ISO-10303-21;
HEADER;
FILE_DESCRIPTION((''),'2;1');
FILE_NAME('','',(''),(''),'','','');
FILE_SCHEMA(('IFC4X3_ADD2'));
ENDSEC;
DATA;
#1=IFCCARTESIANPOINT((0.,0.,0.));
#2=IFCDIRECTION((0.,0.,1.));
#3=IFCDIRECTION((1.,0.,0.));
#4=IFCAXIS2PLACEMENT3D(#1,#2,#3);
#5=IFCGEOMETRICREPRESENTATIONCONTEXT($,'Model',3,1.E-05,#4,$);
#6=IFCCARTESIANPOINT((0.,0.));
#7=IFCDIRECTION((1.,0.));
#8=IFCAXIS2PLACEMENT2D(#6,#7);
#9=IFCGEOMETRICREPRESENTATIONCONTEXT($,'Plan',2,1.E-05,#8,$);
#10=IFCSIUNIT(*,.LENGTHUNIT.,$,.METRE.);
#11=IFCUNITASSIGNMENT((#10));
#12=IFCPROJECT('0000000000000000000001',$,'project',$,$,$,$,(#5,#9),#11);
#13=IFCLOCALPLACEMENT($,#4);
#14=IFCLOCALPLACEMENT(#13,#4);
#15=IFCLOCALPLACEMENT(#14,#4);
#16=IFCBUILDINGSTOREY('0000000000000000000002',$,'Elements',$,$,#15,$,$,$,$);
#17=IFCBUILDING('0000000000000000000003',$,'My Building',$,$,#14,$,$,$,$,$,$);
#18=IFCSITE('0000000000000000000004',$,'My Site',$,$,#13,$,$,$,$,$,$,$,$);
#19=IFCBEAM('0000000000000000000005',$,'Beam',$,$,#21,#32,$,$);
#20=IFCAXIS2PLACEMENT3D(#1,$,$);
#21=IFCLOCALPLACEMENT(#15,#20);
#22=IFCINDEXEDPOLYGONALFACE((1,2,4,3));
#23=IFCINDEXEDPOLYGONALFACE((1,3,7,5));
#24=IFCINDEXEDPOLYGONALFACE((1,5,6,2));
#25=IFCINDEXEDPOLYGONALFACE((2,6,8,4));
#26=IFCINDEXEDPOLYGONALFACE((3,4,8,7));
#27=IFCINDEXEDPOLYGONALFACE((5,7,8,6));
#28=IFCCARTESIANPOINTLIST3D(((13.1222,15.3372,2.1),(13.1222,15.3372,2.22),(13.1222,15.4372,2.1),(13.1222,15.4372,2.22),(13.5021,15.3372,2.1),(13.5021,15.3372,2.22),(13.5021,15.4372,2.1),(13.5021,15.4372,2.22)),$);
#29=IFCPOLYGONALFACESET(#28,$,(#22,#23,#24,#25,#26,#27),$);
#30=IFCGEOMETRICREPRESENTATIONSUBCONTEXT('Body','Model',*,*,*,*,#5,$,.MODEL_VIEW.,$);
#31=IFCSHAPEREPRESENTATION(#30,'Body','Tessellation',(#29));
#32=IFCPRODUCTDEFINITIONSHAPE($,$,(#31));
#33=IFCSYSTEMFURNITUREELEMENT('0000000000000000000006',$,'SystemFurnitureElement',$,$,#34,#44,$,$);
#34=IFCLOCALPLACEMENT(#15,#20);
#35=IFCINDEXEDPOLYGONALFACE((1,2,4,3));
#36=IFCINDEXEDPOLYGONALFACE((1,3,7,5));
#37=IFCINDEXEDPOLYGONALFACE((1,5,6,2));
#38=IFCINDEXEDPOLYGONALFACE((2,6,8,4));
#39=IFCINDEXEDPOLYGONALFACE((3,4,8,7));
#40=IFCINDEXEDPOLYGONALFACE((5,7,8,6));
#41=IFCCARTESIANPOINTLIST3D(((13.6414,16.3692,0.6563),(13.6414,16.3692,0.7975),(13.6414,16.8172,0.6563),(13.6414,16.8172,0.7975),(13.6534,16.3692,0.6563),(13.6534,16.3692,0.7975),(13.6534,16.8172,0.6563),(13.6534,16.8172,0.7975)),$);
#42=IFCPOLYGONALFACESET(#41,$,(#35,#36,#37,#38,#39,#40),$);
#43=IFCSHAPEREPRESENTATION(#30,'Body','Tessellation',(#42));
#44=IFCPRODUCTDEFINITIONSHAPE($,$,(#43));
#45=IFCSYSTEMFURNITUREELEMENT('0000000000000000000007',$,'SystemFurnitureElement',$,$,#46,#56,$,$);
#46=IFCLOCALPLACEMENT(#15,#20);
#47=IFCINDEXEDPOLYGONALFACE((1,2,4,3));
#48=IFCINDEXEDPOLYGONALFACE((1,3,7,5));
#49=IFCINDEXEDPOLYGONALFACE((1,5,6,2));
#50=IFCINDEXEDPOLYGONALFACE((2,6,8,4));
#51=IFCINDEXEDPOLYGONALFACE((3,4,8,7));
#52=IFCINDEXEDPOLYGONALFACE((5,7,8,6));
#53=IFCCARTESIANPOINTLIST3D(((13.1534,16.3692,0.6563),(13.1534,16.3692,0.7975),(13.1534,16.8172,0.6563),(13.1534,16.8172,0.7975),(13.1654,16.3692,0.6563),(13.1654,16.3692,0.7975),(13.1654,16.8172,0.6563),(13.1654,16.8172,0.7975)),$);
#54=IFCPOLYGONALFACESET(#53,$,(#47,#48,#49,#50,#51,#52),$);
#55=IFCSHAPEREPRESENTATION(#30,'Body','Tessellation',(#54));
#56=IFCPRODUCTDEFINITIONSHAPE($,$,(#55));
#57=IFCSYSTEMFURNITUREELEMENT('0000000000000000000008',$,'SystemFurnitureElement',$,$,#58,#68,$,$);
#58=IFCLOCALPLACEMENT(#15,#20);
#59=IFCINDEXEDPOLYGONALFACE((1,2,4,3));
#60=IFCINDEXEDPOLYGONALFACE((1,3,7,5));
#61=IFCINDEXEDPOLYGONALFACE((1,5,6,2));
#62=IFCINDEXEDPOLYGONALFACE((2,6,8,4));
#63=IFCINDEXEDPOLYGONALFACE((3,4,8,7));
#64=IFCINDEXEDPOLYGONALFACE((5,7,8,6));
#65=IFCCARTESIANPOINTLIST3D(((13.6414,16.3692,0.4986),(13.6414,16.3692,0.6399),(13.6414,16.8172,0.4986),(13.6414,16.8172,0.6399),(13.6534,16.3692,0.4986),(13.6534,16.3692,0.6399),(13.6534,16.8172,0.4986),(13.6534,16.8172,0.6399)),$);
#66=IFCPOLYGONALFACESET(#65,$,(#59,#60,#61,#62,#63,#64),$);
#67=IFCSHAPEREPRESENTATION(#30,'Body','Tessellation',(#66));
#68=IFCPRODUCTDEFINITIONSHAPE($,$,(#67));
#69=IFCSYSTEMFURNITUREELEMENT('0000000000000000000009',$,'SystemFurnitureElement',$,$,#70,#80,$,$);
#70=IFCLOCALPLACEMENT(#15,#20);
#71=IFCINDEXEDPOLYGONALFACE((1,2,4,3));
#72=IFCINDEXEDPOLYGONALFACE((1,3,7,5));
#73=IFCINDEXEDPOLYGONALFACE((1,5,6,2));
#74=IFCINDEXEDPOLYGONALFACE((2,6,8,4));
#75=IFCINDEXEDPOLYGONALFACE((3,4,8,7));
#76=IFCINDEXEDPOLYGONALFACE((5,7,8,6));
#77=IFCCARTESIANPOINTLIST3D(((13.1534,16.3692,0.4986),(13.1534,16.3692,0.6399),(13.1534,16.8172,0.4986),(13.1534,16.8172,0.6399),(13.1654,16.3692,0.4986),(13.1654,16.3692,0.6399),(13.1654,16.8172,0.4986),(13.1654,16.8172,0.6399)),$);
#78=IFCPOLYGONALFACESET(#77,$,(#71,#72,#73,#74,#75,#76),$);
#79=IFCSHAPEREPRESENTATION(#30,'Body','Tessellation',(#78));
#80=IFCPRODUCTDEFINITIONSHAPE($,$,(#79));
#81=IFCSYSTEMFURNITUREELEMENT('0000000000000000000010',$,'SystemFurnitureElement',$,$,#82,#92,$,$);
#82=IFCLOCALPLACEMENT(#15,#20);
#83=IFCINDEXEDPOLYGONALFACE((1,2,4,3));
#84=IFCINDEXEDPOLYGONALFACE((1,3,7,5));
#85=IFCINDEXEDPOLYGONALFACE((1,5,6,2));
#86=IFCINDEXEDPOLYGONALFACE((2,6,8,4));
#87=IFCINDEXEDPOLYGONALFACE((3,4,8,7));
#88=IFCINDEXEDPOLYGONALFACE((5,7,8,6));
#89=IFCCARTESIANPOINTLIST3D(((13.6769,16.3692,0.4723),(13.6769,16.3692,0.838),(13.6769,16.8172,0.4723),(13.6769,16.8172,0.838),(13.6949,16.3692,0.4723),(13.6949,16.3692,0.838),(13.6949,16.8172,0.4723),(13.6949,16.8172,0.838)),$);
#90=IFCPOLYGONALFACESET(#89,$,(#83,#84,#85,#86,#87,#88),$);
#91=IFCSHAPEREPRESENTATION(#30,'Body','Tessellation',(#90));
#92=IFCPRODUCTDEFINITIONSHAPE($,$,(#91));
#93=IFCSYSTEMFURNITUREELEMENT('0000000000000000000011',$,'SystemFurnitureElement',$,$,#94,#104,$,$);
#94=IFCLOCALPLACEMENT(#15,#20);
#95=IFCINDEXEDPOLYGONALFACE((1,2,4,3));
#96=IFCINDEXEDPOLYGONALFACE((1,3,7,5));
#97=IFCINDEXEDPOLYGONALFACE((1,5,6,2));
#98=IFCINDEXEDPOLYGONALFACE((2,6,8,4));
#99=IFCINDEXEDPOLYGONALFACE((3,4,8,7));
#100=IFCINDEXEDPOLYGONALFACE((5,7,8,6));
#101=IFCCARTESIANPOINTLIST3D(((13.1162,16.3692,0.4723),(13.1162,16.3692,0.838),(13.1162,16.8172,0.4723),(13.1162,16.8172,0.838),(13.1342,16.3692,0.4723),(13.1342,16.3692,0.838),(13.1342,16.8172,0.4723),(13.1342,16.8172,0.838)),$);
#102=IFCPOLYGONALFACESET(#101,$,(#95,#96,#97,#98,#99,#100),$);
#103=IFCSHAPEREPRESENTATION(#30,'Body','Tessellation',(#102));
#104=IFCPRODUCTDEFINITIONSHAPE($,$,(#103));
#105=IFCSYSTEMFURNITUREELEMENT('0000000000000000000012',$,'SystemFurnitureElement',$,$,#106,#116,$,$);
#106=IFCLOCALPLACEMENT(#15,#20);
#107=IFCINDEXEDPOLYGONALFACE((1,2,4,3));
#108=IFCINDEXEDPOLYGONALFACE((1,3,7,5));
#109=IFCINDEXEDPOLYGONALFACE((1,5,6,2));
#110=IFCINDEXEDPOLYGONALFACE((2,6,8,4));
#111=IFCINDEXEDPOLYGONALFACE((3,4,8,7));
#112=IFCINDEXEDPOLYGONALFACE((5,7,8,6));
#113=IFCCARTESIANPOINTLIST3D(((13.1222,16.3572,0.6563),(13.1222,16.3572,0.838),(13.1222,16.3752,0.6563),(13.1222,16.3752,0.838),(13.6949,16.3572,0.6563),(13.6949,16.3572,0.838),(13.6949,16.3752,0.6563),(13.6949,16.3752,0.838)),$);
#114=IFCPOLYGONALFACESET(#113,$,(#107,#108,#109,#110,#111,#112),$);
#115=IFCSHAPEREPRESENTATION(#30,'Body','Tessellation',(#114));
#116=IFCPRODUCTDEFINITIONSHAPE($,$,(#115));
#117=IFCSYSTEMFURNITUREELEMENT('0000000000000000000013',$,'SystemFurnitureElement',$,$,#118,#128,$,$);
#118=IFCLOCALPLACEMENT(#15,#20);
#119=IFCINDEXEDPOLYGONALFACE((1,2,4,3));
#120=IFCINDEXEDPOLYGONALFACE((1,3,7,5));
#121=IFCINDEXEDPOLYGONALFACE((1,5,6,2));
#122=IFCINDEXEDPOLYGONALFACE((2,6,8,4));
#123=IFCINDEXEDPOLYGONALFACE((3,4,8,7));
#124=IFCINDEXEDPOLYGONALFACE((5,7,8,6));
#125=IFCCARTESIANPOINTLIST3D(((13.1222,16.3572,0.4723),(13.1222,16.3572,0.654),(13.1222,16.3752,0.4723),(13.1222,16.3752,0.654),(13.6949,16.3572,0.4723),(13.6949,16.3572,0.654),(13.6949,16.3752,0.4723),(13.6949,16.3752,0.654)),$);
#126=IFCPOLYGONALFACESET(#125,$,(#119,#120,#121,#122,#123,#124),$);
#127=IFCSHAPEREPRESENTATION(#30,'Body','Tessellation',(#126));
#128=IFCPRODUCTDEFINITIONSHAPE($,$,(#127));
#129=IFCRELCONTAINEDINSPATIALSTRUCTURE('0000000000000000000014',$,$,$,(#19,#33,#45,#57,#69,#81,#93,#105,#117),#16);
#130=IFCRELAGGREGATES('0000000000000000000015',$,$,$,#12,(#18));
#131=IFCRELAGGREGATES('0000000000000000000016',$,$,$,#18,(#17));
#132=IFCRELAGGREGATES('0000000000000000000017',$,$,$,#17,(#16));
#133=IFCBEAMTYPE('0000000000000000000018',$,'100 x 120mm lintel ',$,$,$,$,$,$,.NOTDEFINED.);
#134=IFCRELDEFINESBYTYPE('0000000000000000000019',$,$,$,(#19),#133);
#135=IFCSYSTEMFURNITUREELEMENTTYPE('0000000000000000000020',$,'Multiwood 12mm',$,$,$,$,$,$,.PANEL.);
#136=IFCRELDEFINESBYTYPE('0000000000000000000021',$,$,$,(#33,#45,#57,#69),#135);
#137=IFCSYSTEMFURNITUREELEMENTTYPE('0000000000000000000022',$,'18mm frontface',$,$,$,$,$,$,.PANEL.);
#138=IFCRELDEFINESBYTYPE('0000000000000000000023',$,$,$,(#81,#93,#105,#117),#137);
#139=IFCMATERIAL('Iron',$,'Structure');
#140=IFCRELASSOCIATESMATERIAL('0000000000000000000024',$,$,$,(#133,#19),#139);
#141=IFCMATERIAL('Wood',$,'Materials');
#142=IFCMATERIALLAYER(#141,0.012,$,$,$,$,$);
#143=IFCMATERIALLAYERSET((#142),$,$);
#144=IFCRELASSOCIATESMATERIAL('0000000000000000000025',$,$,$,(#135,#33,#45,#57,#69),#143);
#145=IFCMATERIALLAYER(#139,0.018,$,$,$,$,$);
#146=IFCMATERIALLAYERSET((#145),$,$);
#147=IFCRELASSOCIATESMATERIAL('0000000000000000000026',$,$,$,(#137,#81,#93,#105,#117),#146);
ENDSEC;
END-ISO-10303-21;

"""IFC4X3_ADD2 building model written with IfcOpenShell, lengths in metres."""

from ifc_helpers import new_model, si_unit, frame, origin_with_axes, origin_2d_with_axis, place, context, subcontext, project, spatial, line, indexed_curve, rectangle, outline, extrude, material, layer, layer_set, layer_usage, material_profile, profile_set, profile_usage, type_object, element, save


model = new_model("IFC4X3_ADD2")

# Units and contexts
model_context = context("Model", 3, precision=1e-05, world=origin_with_axes())
plan_context = context("Plan", 2, precision=1e-05, world=origin_2d_with_axis())
body_context = subcontext(model_context, "Body", "Model", "MODEL_VIEW")
ifc_project = project(units=[si_unit("LENGTHUNIT", "METRE")], contexts=[model_context, plan_context])

# Site, building, storey
site_placement = place(None, origin_with_axes())
site = spatial("IfcSite", under=ifc_project, at=site_placement, Name="My Site")
building_placement = place(site_placement, origin_with_axes())
building = spatial("IfcBuilding", under=site, at=building_placement, Name="My Building")
storey_placement = place(building_placement, origin_with_axes())
storey = spatial("IfcBuildingStorey", under=building, at=storey_placement, Name="Elements")

# Beam
ifc_material_1 = material(Name="Iron", Category="Structure")
ifc_material_profile = material_profile(ifc_material_1, rectangle(XDim=0.1, YDim=0.12))
ifc_profile_set = profile_set([ifc_material_profile], Name="blank")
ifc_profile_usage = profile_usage(ifc_profile_set, cardinal=5)
beam_type = type_object("IfcBeamType", Name="100 x 120mm lintel ", PredefinedType="NOTDEFINED", material=ifc_profile_set)
beam_placement = place(storey_placement, frame((13.1222, 15.3872, 2.16), z_axis=(1.0, 0.0, 0.0), x_axis=(0.0, 1.0, 0.0)))
element("IfcBeam", 1, at=beam_placement, inside=storey, type_object=beam_type, material=ifc_profile_usage, Name="Beam", context=body_context, shape_type="SweptSolid", body=[
    extrude(rectangle(XDim=0.1, YDim=0.12), origin_with_axes(), (0.0, 0.0, 1.0), 0.3799),
])

# System furniture elements
ifc_material_2 = material(Name="Wood", Category="Materials")
ifc_layer_1 = layer(ifc_material_2, 0.012)
ifc_layer_set_1 = layer_set([ifc_layer_1])
ifc_layer_usage_1 = layer_usage(ifc_layer_set_1, "AXIS2", "POSITIVE", 0.0)
system_furniture_element_type_1 = type_object("IfcSystemFurnitureElementType", Name="Multiwood 12mm", PredefinedType="PANEL", material=ifc_layer_set_1)
system_furniture_element_1_placement = place(storey_placement, frame((13.6534, 16.3692, 0.6563), z_axis=(0.0, 0.0, 1.0), x_axis=(0.000001, 1.0, 0.0)))
element("IfcSystemFurnitureElement", 2, at=system_furniture_element_1_placement, inside=storey, type_object=system_furniture_element_type_1, material=ifc_layer_usage_1, Name="SystemFurnitureElement", context=body_context, shape_type="SweptSolid", body=[
    extrude(outline(indexed_curve([(0.0, 0.0), (0.0, 0.012), (0.448, 0.012), (0.448, 0.0)], segments=[line(1, 2, 3, 4, 1)])), origin_with_axes(), (0.0, 0.0, 1.0), 0.1413),
])
ifc_layer_usage_2 = layer_usage(ifc_layer_set_1, "AXIS2", "POSITIVE", 0.0)
system_furniture_element_2_placement = place(storey_placement, frame((13.1654, 16.3692, 0.6563), z_axis=(0.0, 0.0, 1.0), x_axis=(0.000001, 1.0, 0.0)))
element("IfcSystemFurnitureElement", 3, at=system_furniture_element_2_placement, inside=storey, type_object=system_furniture_element_type_1, material=ifc_layer_usage_2, Name="SystemFurnitureElement", context=body_context, shape_type="SweptSolid", body=[
    extrude(outline(indexed_curve([(0.0, 0.0), (0.0, 0.012), (0.448, 0.012), (0.448, 0.0)], segments=[line(1, 2, 3, 4, 1)])), origin_with_axes(), (0.0, 0.0, 1.0), 0.1413),
])
ifc_layer_usage_3 = layer_usage(ifc_layer_set_1, "AXIS2", "POSITIVE", 0.0)
system_furniture_element_3_placement = place(storey_placement, frame((13.6534, 16.3692, 0.4986), z_axis=(0.0, 0.0, 1.0), x_axis=(0.000001, 1.0, 0.0)))
element("IfcSystemFurnitureElement", 4, at=system_furniture_element_3_placement, inside=storey, type_object=system_furniture_element_type_1, material=ifc_layer_usage_3, Name="SystemFurnitureElement", context=body_context, shape_type="SweptSolid", body=[
    extrude(outline(indexed_curve([(0.0, 0.0), (0.0, 0.012), (0.448, 0.012), (0.448, 0.0)], segments=[line(1, 2, 3, 4, 1)])), origin_with_axes(), (0.0, 0.0, 1.0), 0.1413),
])
ifc_layer_usage_4 = layer_usage(ifc_layer_set_1, "AXIS2", "POSITIVE", 0.0)
system_furniture_element_4_placement = place(storey_placement, frame((13.1654, 16.3692, 0.4986), z_axis=(0.0, 0.0, 1.0), x_axis=(0.000001, 1.0, 0.0)))
element("IfcSystemFurnitureElement", 5, at=system_furniture_element_4_placement, inside=storey, type_object=system_furniture_element_type_1, material=ifc_layer_usage_4, Name="SystemFurnitureElement", context=body_context, shape_type="SweptSolid", body=[
    extrude(outline(indexed_curve([(0.0, 0.0), (0.0, 0.012), (0.448, 0.012), (0.448, 0.0)], segments=[line(1, 2, 3, 4, 1)])), origin_with_axes(), (0.0, 0.0, 1.0), 0.1413),
])
ifc_layer_2 = layer(ifc_material_1, 0.018)
ifc_layer_set_2 = layer_set([ifc_layer_2])
ifc_layer_usage_5 = layer_usage(ifc_layer_set_2, "AXIS2", "POSITIVE", 0.0)
system_furniture_element_type_2 = type_object("IfcSystemFurnitureElementType", Name="18mm frontface", PredefinedType="PANEL", material=ifc_layer_set_2)
system_furniture_element_5_placement = place(storey_placement, frame((13.6949, 16.3692, 0.4723), z_axis=(0.0, 0.0, 1.0), x_axis=(0.000001, 1.0, 0.0)))
element("IfcSystemFurnitureElement", 6, at=system_furniture_element_5_placement, inside=storey, type_object=system_furniture_element_type_2, material=ifc_layer_usage_5, Name="SystemFurnitureElement", context=body_context, shape_type="SweptSolid", body=[
    extrude(outline(indexed_curve([(0.0, 0.0), (0.0, 0.018), (0.448, 0.018), (0.448, 0.0)], segments=[line(1, 2, 3, 4, 1)])), origin_with_axes(), (0.0, 0.0, 1.0), 0.3657),
])
ifc_layer_usage_6 = layer_usage(ifc_layer_set_2, "AXIS2", "POSITIVE", 0.0)
system_furniture_element_6_placement = place(storey_placement, frame((13.1342, 16.3692, 0.4723), z_axis=(0.0, 0.0, 1.0), x_axis=(0.000001, 1.0, 0.0)))
element("IfcSystemFurnitureElement", 7, at=system_furniture_element_6_placement, inside=storey, type_object=system_furniture_element_type_2, material=ifc_layer_usage_6, Name="SystemFurnitureElement", context=body_context, shape_type="SweptSolid", body=[
    extrude(outline(indexed_curve([(0.0, 0.0), (0.0, 0.018), (0.448, 0.018), (0.448, 0.0)], segments=[line(1, 2, 3, 4, 1)])), origin_with_axes(), (0.0, 0.0, 1.0), 0.3657),
])
ifc_layer_usage_7 = layer_usage(ifc_layer_set_2, "AXIS2", "POSITIVE", 0.0)
system_furniture_element_7_placement = place(storey_placement, frame((13.1222, 16.3572, 0.6563), z_axis=(0.0, 0.0, 1.0), x_axis=(1.0, -0.000001, 0.0)))
element("IfcSystemFurnitureElement", 8, at=system_furniture_element_7_placement, inside=storey, type_object=system_furniture_element_type_2, material=ifc_layer_usage_7, Name="SystemFurnitureElement", context=body_context, shape_type="SweptSolid", body=[
    extrude(outline(indexed_curve([(0.0, 0.0), (0.0, 0.018), (0.5727, 0.018), (0.5727, 0.0)], segments=[line(1, 2, 3, 4, 1)])), origin_with_axes(), (0.0, 0.0, 1.0), 0.1817),
])
ifc_layer_usage_8 = layer_usage(ifc_layer_set_2, "AXIS2", "POSITIVE", 0.0)
system_furniture_element_8_placement = place(storey_placement, frame((13.1222, 16.3572, 0.4723), z_axis=(0.0, 0.0, 1.0), x_axis=(1.0, -0.000001, 0.0)))
element("IfcSystemFurnitureElement", 9, at=system_furniture_element_8_placement, inside=storey, type_object=system_furniture_element_type_2, material=ifc_layer_usage_8, Name="SystemFurnitureElement", context=body_context, shape_type="SweptSolid", body=[
    extrude(outline(indexed_curve([(0.0, 0.0), (0.0, 0.018), (0.5727, 0.018), (0.5727, 0.0)], segments=[line(1, 2, 3, 4, 1)])), origin_with_axes(), (0.0, 0.0, 1.0), 0.1817),
])

save(model, "model.ifc")
